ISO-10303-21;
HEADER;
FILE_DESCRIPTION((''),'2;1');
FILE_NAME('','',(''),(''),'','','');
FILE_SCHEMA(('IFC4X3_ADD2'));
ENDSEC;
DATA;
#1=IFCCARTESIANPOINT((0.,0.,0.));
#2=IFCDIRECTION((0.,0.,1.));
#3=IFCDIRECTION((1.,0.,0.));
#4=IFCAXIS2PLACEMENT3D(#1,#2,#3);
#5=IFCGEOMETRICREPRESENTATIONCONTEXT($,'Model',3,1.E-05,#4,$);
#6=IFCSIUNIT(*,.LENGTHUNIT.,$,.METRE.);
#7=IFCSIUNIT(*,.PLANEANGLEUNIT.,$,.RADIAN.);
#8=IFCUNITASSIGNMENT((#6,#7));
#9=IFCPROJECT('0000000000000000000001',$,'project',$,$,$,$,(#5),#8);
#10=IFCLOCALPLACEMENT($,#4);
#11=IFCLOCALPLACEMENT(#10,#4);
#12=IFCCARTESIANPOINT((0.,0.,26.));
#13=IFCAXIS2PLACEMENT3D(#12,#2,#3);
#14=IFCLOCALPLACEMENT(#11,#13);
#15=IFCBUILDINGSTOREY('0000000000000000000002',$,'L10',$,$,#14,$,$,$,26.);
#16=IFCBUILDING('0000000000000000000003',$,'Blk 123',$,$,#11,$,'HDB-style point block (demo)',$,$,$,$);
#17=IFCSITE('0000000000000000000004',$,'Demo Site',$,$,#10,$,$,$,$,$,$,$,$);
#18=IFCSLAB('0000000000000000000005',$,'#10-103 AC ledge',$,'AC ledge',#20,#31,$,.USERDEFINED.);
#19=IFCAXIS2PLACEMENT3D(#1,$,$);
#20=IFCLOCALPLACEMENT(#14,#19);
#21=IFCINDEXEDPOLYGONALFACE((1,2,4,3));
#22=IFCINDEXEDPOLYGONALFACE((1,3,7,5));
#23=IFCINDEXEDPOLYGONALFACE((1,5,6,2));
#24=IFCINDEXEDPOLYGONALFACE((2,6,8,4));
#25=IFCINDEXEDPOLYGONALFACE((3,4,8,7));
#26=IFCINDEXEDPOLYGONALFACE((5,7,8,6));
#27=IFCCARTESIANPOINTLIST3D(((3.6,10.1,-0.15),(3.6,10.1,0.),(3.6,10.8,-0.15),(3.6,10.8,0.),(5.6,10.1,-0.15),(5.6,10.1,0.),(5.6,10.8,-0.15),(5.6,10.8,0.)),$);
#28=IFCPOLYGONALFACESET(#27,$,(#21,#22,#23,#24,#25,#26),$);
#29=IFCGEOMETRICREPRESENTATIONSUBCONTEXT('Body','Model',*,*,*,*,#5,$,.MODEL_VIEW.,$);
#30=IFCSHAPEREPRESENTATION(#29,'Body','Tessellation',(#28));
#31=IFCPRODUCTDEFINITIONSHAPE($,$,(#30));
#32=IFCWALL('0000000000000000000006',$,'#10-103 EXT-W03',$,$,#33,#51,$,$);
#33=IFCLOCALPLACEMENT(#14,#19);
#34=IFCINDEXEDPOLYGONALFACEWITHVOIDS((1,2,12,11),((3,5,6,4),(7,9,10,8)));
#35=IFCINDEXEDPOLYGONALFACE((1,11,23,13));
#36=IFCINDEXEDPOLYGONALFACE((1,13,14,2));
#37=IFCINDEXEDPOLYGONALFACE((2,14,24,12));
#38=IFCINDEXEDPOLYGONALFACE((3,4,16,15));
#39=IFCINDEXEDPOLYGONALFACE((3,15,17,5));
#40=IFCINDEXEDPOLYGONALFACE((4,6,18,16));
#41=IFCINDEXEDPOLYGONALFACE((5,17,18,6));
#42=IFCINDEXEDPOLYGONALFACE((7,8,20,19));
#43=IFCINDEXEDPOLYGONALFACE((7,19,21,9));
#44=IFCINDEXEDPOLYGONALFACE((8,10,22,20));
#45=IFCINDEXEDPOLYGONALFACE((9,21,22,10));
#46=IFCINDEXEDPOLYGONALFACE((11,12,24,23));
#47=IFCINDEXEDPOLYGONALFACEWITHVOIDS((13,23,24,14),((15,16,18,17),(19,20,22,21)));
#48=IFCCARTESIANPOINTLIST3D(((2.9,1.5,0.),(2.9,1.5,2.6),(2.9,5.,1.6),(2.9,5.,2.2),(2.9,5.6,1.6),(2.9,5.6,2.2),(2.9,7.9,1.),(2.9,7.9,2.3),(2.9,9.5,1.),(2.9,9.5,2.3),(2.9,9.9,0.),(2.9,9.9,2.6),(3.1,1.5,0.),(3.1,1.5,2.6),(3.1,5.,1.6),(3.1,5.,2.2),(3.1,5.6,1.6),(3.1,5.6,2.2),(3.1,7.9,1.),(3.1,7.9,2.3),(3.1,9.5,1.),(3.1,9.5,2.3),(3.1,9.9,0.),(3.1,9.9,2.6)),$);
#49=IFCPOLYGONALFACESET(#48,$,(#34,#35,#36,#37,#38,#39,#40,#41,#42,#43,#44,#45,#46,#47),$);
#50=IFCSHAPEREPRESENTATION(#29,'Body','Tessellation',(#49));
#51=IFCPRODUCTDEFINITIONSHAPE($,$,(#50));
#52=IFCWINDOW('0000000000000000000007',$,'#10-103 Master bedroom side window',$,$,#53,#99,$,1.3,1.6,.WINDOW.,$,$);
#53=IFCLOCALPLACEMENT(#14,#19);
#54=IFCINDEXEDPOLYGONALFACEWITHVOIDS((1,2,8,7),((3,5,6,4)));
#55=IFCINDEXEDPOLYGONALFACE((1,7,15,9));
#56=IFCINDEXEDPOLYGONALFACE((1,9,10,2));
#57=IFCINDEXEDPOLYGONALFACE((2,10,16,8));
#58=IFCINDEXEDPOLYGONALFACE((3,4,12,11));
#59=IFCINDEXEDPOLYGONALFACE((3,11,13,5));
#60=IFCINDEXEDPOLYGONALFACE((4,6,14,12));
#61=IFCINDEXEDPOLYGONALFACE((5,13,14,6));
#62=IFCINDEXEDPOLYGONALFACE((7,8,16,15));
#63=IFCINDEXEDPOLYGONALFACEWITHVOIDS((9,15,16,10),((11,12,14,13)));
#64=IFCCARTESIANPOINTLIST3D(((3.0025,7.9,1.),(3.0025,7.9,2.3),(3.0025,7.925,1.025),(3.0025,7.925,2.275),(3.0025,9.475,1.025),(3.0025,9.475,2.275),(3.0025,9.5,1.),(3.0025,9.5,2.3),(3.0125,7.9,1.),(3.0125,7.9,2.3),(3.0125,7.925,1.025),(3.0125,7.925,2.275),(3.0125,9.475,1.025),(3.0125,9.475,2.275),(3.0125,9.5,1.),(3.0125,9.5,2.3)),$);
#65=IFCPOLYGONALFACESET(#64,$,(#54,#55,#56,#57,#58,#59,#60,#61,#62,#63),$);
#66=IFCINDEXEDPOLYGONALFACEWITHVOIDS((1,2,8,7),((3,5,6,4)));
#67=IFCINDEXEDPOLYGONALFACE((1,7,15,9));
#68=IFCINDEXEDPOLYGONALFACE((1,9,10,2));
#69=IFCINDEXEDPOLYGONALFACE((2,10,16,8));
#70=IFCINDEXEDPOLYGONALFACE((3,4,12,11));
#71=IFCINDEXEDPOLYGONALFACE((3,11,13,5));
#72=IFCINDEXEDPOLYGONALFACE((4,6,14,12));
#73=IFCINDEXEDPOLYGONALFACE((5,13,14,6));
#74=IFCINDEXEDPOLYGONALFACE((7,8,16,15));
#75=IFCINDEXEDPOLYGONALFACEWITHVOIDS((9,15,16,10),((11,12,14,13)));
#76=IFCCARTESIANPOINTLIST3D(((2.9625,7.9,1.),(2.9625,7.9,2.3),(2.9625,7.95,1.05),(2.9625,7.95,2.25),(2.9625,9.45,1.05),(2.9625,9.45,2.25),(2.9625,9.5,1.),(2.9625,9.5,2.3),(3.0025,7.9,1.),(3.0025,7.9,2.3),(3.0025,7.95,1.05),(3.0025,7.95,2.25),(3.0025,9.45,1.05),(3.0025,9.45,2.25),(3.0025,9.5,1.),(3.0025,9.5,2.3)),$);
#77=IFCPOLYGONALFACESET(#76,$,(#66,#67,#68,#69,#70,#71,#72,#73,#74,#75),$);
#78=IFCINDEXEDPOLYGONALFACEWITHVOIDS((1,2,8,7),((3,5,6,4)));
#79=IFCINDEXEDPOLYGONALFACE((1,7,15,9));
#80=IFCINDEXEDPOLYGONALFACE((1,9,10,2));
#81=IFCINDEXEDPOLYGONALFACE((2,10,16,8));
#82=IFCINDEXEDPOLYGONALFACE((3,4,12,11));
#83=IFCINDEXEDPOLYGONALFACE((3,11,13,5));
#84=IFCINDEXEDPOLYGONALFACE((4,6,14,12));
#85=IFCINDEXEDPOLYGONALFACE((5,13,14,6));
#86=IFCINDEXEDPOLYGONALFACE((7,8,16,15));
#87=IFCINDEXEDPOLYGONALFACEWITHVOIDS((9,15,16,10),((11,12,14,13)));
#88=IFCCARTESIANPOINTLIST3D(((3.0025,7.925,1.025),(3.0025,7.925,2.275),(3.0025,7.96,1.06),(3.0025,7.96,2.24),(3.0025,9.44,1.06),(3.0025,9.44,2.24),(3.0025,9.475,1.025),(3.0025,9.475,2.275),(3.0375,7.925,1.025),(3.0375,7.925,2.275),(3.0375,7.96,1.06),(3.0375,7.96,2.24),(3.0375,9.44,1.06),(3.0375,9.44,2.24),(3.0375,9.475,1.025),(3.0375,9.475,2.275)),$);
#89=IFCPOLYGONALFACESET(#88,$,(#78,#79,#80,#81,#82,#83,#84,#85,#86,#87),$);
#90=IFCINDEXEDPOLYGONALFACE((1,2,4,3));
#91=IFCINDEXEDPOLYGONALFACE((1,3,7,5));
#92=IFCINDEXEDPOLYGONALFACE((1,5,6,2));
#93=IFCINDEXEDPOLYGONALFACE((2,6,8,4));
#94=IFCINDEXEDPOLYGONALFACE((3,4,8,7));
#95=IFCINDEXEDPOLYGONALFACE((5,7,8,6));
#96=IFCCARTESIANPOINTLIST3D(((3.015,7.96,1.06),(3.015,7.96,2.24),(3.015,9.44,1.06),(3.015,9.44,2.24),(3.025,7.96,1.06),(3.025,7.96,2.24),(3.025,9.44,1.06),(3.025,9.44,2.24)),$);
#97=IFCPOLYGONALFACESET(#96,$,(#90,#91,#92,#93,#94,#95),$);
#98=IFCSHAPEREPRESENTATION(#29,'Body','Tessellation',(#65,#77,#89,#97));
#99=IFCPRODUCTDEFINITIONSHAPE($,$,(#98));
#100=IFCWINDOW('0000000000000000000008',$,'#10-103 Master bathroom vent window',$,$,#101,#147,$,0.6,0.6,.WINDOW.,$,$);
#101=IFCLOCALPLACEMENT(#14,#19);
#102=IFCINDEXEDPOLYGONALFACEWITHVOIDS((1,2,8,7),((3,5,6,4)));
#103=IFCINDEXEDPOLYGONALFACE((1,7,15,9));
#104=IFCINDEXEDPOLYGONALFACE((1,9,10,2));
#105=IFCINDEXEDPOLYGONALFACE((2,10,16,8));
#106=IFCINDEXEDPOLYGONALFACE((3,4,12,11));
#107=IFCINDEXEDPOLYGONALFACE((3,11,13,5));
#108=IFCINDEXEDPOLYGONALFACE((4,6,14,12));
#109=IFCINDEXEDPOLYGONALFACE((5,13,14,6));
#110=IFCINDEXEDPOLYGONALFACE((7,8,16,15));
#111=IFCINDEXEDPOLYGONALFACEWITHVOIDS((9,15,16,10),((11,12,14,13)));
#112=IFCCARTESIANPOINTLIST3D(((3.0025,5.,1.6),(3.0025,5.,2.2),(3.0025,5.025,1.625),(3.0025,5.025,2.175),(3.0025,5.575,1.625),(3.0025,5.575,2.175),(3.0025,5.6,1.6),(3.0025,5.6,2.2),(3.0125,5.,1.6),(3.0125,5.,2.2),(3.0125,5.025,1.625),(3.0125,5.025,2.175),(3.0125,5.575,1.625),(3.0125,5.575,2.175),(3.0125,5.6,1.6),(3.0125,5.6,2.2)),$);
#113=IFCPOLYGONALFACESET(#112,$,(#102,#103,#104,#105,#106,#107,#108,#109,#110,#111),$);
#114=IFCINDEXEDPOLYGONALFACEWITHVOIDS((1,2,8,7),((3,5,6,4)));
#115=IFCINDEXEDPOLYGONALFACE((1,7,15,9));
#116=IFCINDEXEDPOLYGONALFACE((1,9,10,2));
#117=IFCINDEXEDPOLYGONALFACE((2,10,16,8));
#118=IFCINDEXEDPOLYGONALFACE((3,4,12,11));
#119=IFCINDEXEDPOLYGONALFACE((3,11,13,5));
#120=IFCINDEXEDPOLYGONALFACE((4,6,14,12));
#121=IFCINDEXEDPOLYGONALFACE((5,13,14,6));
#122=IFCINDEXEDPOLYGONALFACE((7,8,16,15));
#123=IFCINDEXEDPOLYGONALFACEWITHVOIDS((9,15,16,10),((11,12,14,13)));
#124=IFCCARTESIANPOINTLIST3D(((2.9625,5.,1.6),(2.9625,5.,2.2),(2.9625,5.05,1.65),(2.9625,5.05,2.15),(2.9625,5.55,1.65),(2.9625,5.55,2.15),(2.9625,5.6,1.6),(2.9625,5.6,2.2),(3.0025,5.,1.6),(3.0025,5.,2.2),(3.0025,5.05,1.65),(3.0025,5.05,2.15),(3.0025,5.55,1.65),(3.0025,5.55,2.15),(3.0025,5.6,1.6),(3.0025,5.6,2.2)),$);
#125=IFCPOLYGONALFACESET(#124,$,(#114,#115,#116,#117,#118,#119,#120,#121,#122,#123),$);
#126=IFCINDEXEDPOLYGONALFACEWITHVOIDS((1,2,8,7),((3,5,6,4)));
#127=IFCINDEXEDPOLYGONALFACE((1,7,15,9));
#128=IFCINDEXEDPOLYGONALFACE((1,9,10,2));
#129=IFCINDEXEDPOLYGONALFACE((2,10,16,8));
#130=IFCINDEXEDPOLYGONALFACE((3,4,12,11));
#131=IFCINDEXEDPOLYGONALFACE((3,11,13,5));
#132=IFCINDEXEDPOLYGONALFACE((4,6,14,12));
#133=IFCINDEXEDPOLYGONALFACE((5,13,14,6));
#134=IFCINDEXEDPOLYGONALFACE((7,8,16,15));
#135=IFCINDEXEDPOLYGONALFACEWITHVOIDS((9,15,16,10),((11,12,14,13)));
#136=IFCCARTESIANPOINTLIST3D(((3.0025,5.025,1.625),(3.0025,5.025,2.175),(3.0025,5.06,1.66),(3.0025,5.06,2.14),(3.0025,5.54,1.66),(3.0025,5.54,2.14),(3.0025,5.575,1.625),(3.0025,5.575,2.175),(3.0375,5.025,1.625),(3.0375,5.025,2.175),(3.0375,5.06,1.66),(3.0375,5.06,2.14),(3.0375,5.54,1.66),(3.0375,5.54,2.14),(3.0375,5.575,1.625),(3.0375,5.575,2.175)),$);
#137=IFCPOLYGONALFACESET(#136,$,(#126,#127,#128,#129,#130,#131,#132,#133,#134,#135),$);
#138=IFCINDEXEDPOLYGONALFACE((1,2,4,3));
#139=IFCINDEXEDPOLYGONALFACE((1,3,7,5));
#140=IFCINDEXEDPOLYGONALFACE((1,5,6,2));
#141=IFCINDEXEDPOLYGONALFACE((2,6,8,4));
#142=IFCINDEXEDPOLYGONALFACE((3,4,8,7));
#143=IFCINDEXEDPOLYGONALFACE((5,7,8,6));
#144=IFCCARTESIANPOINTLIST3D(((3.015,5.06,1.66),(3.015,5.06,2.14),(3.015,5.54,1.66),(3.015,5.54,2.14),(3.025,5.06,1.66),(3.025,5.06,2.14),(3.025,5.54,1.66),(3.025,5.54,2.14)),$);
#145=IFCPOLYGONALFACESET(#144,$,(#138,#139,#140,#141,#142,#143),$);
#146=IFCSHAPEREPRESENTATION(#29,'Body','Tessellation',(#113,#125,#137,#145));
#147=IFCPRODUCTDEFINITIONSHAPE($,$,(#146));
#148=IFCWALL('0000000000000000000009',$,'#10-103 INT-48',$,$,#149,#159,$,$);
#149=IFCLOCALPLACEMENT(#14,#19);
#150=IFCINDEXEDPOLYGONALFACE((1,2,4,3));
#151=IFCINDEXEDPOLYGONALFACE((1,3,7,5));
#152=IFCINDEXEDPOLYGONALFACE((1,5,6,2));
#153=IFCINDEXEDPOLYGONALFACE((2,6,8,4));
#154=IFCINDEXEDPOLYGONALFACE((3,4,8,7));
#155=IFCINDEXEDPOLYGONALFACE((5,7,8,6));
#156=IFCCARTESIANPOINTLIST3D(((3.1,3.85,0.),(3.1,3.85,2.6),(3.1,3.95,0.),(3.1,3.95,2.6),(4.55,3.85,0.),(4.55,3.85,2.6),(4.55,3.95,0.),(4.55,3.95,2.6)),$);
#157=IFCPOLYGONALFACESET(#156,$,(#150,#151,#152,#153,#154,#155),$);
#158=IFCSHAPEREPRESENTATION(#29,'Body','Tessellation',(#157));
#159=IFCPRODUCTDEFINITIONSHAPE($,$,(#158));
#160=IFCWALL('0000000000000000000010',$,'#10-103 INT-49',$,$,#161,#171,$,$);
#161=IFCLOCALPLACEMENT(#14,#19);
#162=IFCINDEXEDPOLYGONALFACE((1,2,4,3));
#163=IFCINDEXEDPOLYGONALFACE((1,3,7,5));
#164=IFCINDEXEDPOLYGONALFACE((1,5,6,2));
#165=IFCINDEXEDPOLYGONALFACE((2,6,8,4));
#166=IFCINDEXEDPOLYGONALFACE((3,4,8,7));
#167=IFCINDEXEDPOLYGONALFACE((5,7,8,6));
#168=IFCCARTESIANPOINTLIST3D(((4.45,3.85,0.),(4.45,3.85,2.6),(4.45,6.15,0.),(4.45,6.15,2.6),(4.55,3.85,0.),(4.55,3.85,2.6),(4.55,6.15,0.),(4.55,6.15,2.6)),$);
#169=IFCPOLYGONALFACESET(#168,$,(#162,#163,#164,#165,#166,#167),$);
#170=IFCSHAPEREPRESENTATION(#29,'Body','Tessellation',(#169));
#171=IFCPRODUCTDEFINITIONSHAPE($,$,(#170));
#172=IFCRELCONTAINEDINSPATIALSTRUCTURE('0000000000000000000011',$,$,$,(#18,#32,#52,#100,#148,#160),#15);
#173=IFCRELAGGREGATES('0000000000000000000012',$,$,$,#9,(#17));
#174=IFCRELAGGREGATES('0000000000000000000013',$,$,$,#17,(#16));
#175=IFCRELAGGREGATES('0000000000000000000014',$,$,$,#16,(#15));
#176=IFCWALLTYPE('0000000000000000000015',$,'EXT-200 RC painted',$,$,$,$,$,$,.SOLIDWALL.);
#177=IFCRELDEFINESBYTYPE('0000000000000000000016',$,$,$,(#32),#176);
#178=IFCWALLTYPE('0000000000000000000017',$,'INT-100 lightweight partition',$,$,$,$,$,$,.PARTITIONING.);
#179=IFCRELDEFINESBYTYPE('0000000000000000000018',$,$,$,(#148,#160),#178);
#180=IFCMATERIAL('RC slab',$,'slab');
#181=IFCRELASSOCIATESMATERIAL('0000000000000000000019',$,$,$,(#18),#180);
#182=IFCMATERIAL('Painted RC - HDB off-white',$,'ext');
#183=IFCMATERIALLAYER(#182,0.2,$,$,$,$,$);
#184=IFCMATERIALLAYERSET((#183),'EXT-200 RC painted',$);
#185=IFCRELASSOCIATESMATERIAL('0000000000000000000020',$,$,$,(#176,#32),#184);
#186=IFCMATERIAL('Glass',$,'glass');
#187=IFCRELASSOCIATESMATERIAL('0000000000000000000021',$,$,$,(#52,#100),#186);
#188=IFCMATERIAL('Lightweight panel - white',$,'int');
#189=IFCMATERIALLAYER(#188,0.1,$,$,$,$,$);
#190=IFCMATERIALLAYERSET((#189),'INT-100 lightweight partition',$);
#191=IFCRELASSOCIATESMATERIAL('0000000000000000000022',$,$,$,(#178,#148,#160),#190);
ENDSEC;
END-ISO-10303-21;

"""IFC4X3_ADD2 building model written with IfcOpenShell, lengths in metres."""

from ifc_helpers import new_model, si_unit, frame, origin, origin_with_axes, place, context, subcontext, project, spatial, polyline, line, indexed_curve, outline, extrude, material, layer, layer_set, layer_usage, type_object, element, fill, save


model = new_model("IFC4X3_ADD2")

# Units and contexts
model_context = context("Model", 3, precision=1e-05, world=origin_with_axes())
body_context = subcontext(model_context, "Body", "Model", "MODEL_VIEW")
ifc_project = project(units=[si_unit("LENGTHUNIT", "METRE"), si_unit("PLANEANGLEUNIT", "RADIAN")], contexts=[model_context])

# Site, building, storey
site_placement = place(None, origin_with_axes())
site = spatial("IfcSite", under=ifc_project, at=site_placement, Name="Demo Site")
building_placement = place(site_placement, origin_with_axes())
building = spatial("IfcBuilding", under=site, at=building_placement, Name="Blk 123", LongName="HDB-style point block (demo)")
storey_placement = place(building_placement, frame((0.0, 0.0, 26.0), z_axis=(0.0, 0.0, 1.0), x_axis=(1.0, 0.0, 0.0)))
storey = spatial("IfcBuildingStorey", under=building, at=storey_placement, Name="L10", Elevation=26.0)

# Slab
ifc_material_1 = material(Name="RC slab", Category="slab")
slab_placement = place(storey_placement, frame((4.6, 10.45, -0.15), z_axis=(0.0, 0.0, 1.0), x_axis=(1.0, 0.0, 0.0)))
element("IfcSlab", 1, at=slab_placement, inside=storey, material=ifc_material_1, Name="#10-103 AC ledge", ObjectType="AC ledge", PredefinedType="USERDEFINED", context=body_context, shape_type="SweptSolid", body=[
    extrude(outline(polyline([(1.0, -0.35), (1.0, 0.35), (-1.0, 0.35), (-1.0, -0.35), (1.0, -0.35)])), origin(), (0.0, 0.0, 1.0), 0.15),
])

# Wall, openings, windows
ifc_material_2 = material(Name="Painted RC - HDB off-white", Category="ext")
ifc_layer_1 = layer(ifc_material_2, 0.2)
ifc_layer_set_1 = layer_set([ifc_layer_1], Name="EXT-200 RC painted")
ifc_layer_usage_1 = layer_usage(ifc_layer_set_1, "AXIS2", "POSITIVE", 0.0)
wall_type_1 = type_object("IfcWallType", Name="EXT-200 RC painted", PredefinedType="SOLIDWALL", material=ifc_layer_set_1)
wall_1_placement = place(storey_placement, frame((2.9, 9.9, 0.0), z_axis=(0.0, 0.0, 1.0), x_axis=(0.0, -1.0, 0.0)))
wall_1 = element("IfcWall", 2, at=wall_1_placement, inside=storey, type_object=wall_type_1, material=ifc_layer_usage_1, Name="#10-103 EXT-W03", context=body_context, shape_type="SweptSolid", body=[
    extrude(outline(indexed_curve([(0.0, 0.0), (0.0, 0.2), (8.4, 0.2), (8.4, 0.0), (0.0, 0.0)], self_intersect=False)), origin_with_axes(), (0.0, 0.0, 1.0), 2.6),
])
opening_1_placement = place(wall_1_placement, frame((0.4, -0.1, 1.0), z_axis=(0.0, 0.0, 1.0), x_axis=(1.0, 0.0, 0.0)))
opening_1 = element("IfcOpeningElement", 3, at=opening_1_placement, cuts=wall_1, context=body_context, shape_type="SweptSolid", body=[
    extrude(outline(indexed_curve([(0.0, 0.0), (0.0, 0.4), (1.6, 0.4), (1.6, 0.0), (0.0, 0.0)], self_intersect=False)), origin_with_axes(), (0.0, 0.0, 1.0), 1.3),
])
opening_2_placement = place(wall_1_placement, frame((4.3, -0.1, 1.6), z_axis=(0.0, 0.0, 1.0), x_axis=(1.0, 0.0, 0.0)))
opening_2 = element("IfcOpeningElement", 4, at=opening_2_placement, cuts=wall_1, context=body_context, shape_type="SweptSolid", body=[
    extrude(outline(indexed_curve([(0.0, 0.0), (0.0, 0.4), (0.6, 0.4), (0.6, 0.0), (0.0, 0.0)], self_intersect=False)), origin_with_axes(), (0.0, 0.0, 1.0), 0.6),
])
ifc_material_3 = material(Name="Glass", Category="glass")
window_1_placement = place(opening_1_placement, frame((0.0, 0.1125, 0.0), z_axis=(0.0, 0.0, 1.0), x_axis=(1.0, 0.0, 0.0)))
window_1 = element("IfcWindow", 5, at=window_1_placement, inside=storey, material=ifc_material_3, Name="#10-103 Master bedroom side window", OverallHeight=1.3, OverallWidth=1.6, PredefinedType="WINDOW", context=body_context, shape_type="SweptSolid", body=[
    extrude(outline(indexed_curve([(0.0, 0.0), (1.6, 0.0), (1.6, 1.3), (0.0, 1.3)], segments=[line(1, 2, 3, 4, 1)]), holes=[indexed_curve([(0.025, 0.025), (1.575, 0.025), (1.575, 1.275), (0.025, 1.275)], segments=[line(1, 2, 3, 4, 1)])]), frame((0.0, 0.09, 0.0), z_axis=(0.0, -1.0, 0.0), x_axis=(1.0, 0.0, 0.0)), (0.0, 0.0, -1.0), 0.01),
    extrude(outline(indexed_curve([(0.0, 0.0), (1.6, 0.0), (1.6, 1.3), (0.0, 1.3)], segments=[line(1, 2, 3, 4, 1)]), holes=[indexed_curve([(0.05, 0.05), (1.55, 0.05), (1.55, 1.25), (0.05, 1.25)], segments=[line(1, 2, 3, 4, 1)])]), frame((0.0, 0.05, 0.0), z_axis=(0.0, -1.0, 0.0), x_axis=(1.0, 0.0, 0.0)), (0.0, 0.0, -1.0), 0.04),
    extrude(outline(indexed_curve([(0.0, 0.0), (1.55, 0.0), (1.55, 1.25), (0.0, 1.25)], segments=[line(1, 2, 3, 4, 1)]), holes=[indexed_curve([(0.035, 0.035), (1.515, 0.035), (1.515, 1.215), (0.035, 1.215)], segments=[line(1, 2, 3, 4, 1)])]), frame((0.025, 0.09, 0.025), z_axis=(0.0, -1.0, 0.0), x_axis=(1.0, 0.0, 0.0)), (0.0, 0.0, -1.0), 0.035),
    extrude(outline(indexed_curve([(0.035, 0.035), (1.515, 0.035), (1.515, 1.215), (0.035, 1.215)], segments=[line(1, 2, 3, 4, 1)])), frame((0.025, 0.1025, 0.025), z_axis=(0.0, -1.0, 0.0), x_axis=(1.0, 0.0, 0.0)), (0.0, 0.0, -1.0), 0.01),
])
fill(opening_1, window_1)
window_2_placement = place(opening_2_placement, frame((0.0, 0.1125, 0.0), z_axis=(0.0, 0.0, 1.0), x_axis=(1.0, 0.0, 0.0)))
window_2 = element("IfcWindow", 6, at=window_2_placement, inside=storey, material=ifc_material_3, Name="#10-103 Master bathroom vent window", OverallHeight=0.6, OverallWidth=0.6, PredefinedType="WINDOW", context=body_context, shape_type="SweptSolid", body=[
    extrude(outline(indexed_curve([(0.0, 0.0), (0.6, 0.0), (0.6, 0.6), (0.0, 0.6)], segments=[line(1, 2, 3, 4, 1)]), holes=[indexed_curve([(0.025, 0.025), (0.575, 0.025), (0.575, 0.575), (0.025, 0.575)], segments=[line(1, 2, 3, 4, 1)])]), frame((0.0, 0.09, 0.0), z_axis=(0.0, -1.0, 0.0), x_axis=(1.0, 0.0, 0.0)), (0.0, 0.0, -1.0), 0.01),
    extrude(outline(indexed_curve([(0.0, 0.0), (0.6, 0.0), (0.6, 0.6), (0.0, 0.6)], segments=[line(1, 2, 3, 4, 1)]), holes=[indexed_curve([(0.05, 0.05), (0.55, 0.05), (0.55, 0.55), (0.05, 0.55)], segments=[line(1, 2, 3, 4, 1)])]), frame((0.0, 0.05, 0.0), z_axis=(0.0, -1.0, 0.0), x_axis=(1.0, 0.0, 0.0)), (0.0, 0.0, -1.0), 0.04),
    extrude(outline(indexed_curve([(0.0, 0.0), (0.55, 0.0), (0.55, 0.55), (0.0, 0.55)], segments=[line(1, 2, 3, 4, 1)]), holes=[indexed_curve([(0.035, 0.035), (0.515, 0.035), (0.515, 0.515), (0.035, 0.515)], segments=[line(1, 2, 3, 4, 1)])]), frame((0.025, 0.09, 0.025), z_axis=(0.0, -1.0, 0.0), x_axis=(1.0, 0.0, 0.0)), (0.0, 0.0, -1.0), 0.035),
    extrude(outline(indexed_curve([(0.035, 0.035), (0.515, 0.035), (0.515, 0.515), (0.035, 0.515)], segments=[line(1, 2, 3, 4, 1)])), frame((0.025, 0.1025, 0.025), z_axis=(0.0, -1.0, 0.0), x_axis=(1.0, 0.0, 0.0)), (0.0, 0.0, -1.0), 0.01),
])
fill(opening_2, window_2)

# Shared definitions
ifc_material_4 = material(Name="Lightweight panel - white", Category="int")
ifc_layer_2 = layer(ifc_material_4, 0.1)
ifc_layer_set_2 = layer_set([ifc_layer_2], Name="INT-100 lightweight partition")
ifc_layer_usage_2 = layer_usage(ifc_layer_set_2, "AXIS2", "POSITIVE", -0.05)
wall_type_2 = type_object("IfcWallType", Name="INT-100 lightweight partition", PredefinedType="PARTITIONING", material=ifc_layer_set_2)

# Walls
wall_2_placement = place(storey_placement, frame((3.1, 3.9, 0.0), z_axis=(0.0, 0.0, 1.0), x_axis=(1.0, 0.0, 0.0)))
element("IfcWall", 7, at=wall_2_placement, inside=storey, type_object=wall_type_2, material=ifc_layer_usage_2, Name="#10-103 INT-48", context=body_context, shape_type="SweptSolid", body=[
    extrude(outline(indexed_curve([(0.0, 0.0), (0.0, 0.1), (1.45, 0.1), (1.45, 0.0), (0.0, 0.0)], self_intersect=False)), frame((0.0, -0.05, 0.0), z_axis=(0.0, 0.0, 1.0), x_axis=(1.0, 0.0, 0.0)), (0.0, 0.0, 1.0), 2.6),
])
wall_3_placement = place(storey_placement, frame((4.5, 3.85, 0.0), z_axis=(0.0, 0.0, 1.0), x_axis=(0.0, 1.0, 0.0)))
element("IfcWall", 8, at=wall_3_placement, inside=storey, type_object=wall_type_2, material=ifc_layer_usage_2, Name="#10-103 INT-49", context=body_context, shape_type="SweptSolid", body=[
    extrude(outline(indexed_curve([(0.0, 0.0), (0.0, 0.1), (2.3, 0.1), (2.3, 0.0), (0.0, 0.0)], self_intersect=False)), frame((0.0, -0.05, 0.0), z_axis=(0.0, 0.0, 1.0), x_axis=(1.0, 0.0, 0.0)), (0.0, 0.0, 1.0), 2.6),
])

save(model, "model.ifc")
